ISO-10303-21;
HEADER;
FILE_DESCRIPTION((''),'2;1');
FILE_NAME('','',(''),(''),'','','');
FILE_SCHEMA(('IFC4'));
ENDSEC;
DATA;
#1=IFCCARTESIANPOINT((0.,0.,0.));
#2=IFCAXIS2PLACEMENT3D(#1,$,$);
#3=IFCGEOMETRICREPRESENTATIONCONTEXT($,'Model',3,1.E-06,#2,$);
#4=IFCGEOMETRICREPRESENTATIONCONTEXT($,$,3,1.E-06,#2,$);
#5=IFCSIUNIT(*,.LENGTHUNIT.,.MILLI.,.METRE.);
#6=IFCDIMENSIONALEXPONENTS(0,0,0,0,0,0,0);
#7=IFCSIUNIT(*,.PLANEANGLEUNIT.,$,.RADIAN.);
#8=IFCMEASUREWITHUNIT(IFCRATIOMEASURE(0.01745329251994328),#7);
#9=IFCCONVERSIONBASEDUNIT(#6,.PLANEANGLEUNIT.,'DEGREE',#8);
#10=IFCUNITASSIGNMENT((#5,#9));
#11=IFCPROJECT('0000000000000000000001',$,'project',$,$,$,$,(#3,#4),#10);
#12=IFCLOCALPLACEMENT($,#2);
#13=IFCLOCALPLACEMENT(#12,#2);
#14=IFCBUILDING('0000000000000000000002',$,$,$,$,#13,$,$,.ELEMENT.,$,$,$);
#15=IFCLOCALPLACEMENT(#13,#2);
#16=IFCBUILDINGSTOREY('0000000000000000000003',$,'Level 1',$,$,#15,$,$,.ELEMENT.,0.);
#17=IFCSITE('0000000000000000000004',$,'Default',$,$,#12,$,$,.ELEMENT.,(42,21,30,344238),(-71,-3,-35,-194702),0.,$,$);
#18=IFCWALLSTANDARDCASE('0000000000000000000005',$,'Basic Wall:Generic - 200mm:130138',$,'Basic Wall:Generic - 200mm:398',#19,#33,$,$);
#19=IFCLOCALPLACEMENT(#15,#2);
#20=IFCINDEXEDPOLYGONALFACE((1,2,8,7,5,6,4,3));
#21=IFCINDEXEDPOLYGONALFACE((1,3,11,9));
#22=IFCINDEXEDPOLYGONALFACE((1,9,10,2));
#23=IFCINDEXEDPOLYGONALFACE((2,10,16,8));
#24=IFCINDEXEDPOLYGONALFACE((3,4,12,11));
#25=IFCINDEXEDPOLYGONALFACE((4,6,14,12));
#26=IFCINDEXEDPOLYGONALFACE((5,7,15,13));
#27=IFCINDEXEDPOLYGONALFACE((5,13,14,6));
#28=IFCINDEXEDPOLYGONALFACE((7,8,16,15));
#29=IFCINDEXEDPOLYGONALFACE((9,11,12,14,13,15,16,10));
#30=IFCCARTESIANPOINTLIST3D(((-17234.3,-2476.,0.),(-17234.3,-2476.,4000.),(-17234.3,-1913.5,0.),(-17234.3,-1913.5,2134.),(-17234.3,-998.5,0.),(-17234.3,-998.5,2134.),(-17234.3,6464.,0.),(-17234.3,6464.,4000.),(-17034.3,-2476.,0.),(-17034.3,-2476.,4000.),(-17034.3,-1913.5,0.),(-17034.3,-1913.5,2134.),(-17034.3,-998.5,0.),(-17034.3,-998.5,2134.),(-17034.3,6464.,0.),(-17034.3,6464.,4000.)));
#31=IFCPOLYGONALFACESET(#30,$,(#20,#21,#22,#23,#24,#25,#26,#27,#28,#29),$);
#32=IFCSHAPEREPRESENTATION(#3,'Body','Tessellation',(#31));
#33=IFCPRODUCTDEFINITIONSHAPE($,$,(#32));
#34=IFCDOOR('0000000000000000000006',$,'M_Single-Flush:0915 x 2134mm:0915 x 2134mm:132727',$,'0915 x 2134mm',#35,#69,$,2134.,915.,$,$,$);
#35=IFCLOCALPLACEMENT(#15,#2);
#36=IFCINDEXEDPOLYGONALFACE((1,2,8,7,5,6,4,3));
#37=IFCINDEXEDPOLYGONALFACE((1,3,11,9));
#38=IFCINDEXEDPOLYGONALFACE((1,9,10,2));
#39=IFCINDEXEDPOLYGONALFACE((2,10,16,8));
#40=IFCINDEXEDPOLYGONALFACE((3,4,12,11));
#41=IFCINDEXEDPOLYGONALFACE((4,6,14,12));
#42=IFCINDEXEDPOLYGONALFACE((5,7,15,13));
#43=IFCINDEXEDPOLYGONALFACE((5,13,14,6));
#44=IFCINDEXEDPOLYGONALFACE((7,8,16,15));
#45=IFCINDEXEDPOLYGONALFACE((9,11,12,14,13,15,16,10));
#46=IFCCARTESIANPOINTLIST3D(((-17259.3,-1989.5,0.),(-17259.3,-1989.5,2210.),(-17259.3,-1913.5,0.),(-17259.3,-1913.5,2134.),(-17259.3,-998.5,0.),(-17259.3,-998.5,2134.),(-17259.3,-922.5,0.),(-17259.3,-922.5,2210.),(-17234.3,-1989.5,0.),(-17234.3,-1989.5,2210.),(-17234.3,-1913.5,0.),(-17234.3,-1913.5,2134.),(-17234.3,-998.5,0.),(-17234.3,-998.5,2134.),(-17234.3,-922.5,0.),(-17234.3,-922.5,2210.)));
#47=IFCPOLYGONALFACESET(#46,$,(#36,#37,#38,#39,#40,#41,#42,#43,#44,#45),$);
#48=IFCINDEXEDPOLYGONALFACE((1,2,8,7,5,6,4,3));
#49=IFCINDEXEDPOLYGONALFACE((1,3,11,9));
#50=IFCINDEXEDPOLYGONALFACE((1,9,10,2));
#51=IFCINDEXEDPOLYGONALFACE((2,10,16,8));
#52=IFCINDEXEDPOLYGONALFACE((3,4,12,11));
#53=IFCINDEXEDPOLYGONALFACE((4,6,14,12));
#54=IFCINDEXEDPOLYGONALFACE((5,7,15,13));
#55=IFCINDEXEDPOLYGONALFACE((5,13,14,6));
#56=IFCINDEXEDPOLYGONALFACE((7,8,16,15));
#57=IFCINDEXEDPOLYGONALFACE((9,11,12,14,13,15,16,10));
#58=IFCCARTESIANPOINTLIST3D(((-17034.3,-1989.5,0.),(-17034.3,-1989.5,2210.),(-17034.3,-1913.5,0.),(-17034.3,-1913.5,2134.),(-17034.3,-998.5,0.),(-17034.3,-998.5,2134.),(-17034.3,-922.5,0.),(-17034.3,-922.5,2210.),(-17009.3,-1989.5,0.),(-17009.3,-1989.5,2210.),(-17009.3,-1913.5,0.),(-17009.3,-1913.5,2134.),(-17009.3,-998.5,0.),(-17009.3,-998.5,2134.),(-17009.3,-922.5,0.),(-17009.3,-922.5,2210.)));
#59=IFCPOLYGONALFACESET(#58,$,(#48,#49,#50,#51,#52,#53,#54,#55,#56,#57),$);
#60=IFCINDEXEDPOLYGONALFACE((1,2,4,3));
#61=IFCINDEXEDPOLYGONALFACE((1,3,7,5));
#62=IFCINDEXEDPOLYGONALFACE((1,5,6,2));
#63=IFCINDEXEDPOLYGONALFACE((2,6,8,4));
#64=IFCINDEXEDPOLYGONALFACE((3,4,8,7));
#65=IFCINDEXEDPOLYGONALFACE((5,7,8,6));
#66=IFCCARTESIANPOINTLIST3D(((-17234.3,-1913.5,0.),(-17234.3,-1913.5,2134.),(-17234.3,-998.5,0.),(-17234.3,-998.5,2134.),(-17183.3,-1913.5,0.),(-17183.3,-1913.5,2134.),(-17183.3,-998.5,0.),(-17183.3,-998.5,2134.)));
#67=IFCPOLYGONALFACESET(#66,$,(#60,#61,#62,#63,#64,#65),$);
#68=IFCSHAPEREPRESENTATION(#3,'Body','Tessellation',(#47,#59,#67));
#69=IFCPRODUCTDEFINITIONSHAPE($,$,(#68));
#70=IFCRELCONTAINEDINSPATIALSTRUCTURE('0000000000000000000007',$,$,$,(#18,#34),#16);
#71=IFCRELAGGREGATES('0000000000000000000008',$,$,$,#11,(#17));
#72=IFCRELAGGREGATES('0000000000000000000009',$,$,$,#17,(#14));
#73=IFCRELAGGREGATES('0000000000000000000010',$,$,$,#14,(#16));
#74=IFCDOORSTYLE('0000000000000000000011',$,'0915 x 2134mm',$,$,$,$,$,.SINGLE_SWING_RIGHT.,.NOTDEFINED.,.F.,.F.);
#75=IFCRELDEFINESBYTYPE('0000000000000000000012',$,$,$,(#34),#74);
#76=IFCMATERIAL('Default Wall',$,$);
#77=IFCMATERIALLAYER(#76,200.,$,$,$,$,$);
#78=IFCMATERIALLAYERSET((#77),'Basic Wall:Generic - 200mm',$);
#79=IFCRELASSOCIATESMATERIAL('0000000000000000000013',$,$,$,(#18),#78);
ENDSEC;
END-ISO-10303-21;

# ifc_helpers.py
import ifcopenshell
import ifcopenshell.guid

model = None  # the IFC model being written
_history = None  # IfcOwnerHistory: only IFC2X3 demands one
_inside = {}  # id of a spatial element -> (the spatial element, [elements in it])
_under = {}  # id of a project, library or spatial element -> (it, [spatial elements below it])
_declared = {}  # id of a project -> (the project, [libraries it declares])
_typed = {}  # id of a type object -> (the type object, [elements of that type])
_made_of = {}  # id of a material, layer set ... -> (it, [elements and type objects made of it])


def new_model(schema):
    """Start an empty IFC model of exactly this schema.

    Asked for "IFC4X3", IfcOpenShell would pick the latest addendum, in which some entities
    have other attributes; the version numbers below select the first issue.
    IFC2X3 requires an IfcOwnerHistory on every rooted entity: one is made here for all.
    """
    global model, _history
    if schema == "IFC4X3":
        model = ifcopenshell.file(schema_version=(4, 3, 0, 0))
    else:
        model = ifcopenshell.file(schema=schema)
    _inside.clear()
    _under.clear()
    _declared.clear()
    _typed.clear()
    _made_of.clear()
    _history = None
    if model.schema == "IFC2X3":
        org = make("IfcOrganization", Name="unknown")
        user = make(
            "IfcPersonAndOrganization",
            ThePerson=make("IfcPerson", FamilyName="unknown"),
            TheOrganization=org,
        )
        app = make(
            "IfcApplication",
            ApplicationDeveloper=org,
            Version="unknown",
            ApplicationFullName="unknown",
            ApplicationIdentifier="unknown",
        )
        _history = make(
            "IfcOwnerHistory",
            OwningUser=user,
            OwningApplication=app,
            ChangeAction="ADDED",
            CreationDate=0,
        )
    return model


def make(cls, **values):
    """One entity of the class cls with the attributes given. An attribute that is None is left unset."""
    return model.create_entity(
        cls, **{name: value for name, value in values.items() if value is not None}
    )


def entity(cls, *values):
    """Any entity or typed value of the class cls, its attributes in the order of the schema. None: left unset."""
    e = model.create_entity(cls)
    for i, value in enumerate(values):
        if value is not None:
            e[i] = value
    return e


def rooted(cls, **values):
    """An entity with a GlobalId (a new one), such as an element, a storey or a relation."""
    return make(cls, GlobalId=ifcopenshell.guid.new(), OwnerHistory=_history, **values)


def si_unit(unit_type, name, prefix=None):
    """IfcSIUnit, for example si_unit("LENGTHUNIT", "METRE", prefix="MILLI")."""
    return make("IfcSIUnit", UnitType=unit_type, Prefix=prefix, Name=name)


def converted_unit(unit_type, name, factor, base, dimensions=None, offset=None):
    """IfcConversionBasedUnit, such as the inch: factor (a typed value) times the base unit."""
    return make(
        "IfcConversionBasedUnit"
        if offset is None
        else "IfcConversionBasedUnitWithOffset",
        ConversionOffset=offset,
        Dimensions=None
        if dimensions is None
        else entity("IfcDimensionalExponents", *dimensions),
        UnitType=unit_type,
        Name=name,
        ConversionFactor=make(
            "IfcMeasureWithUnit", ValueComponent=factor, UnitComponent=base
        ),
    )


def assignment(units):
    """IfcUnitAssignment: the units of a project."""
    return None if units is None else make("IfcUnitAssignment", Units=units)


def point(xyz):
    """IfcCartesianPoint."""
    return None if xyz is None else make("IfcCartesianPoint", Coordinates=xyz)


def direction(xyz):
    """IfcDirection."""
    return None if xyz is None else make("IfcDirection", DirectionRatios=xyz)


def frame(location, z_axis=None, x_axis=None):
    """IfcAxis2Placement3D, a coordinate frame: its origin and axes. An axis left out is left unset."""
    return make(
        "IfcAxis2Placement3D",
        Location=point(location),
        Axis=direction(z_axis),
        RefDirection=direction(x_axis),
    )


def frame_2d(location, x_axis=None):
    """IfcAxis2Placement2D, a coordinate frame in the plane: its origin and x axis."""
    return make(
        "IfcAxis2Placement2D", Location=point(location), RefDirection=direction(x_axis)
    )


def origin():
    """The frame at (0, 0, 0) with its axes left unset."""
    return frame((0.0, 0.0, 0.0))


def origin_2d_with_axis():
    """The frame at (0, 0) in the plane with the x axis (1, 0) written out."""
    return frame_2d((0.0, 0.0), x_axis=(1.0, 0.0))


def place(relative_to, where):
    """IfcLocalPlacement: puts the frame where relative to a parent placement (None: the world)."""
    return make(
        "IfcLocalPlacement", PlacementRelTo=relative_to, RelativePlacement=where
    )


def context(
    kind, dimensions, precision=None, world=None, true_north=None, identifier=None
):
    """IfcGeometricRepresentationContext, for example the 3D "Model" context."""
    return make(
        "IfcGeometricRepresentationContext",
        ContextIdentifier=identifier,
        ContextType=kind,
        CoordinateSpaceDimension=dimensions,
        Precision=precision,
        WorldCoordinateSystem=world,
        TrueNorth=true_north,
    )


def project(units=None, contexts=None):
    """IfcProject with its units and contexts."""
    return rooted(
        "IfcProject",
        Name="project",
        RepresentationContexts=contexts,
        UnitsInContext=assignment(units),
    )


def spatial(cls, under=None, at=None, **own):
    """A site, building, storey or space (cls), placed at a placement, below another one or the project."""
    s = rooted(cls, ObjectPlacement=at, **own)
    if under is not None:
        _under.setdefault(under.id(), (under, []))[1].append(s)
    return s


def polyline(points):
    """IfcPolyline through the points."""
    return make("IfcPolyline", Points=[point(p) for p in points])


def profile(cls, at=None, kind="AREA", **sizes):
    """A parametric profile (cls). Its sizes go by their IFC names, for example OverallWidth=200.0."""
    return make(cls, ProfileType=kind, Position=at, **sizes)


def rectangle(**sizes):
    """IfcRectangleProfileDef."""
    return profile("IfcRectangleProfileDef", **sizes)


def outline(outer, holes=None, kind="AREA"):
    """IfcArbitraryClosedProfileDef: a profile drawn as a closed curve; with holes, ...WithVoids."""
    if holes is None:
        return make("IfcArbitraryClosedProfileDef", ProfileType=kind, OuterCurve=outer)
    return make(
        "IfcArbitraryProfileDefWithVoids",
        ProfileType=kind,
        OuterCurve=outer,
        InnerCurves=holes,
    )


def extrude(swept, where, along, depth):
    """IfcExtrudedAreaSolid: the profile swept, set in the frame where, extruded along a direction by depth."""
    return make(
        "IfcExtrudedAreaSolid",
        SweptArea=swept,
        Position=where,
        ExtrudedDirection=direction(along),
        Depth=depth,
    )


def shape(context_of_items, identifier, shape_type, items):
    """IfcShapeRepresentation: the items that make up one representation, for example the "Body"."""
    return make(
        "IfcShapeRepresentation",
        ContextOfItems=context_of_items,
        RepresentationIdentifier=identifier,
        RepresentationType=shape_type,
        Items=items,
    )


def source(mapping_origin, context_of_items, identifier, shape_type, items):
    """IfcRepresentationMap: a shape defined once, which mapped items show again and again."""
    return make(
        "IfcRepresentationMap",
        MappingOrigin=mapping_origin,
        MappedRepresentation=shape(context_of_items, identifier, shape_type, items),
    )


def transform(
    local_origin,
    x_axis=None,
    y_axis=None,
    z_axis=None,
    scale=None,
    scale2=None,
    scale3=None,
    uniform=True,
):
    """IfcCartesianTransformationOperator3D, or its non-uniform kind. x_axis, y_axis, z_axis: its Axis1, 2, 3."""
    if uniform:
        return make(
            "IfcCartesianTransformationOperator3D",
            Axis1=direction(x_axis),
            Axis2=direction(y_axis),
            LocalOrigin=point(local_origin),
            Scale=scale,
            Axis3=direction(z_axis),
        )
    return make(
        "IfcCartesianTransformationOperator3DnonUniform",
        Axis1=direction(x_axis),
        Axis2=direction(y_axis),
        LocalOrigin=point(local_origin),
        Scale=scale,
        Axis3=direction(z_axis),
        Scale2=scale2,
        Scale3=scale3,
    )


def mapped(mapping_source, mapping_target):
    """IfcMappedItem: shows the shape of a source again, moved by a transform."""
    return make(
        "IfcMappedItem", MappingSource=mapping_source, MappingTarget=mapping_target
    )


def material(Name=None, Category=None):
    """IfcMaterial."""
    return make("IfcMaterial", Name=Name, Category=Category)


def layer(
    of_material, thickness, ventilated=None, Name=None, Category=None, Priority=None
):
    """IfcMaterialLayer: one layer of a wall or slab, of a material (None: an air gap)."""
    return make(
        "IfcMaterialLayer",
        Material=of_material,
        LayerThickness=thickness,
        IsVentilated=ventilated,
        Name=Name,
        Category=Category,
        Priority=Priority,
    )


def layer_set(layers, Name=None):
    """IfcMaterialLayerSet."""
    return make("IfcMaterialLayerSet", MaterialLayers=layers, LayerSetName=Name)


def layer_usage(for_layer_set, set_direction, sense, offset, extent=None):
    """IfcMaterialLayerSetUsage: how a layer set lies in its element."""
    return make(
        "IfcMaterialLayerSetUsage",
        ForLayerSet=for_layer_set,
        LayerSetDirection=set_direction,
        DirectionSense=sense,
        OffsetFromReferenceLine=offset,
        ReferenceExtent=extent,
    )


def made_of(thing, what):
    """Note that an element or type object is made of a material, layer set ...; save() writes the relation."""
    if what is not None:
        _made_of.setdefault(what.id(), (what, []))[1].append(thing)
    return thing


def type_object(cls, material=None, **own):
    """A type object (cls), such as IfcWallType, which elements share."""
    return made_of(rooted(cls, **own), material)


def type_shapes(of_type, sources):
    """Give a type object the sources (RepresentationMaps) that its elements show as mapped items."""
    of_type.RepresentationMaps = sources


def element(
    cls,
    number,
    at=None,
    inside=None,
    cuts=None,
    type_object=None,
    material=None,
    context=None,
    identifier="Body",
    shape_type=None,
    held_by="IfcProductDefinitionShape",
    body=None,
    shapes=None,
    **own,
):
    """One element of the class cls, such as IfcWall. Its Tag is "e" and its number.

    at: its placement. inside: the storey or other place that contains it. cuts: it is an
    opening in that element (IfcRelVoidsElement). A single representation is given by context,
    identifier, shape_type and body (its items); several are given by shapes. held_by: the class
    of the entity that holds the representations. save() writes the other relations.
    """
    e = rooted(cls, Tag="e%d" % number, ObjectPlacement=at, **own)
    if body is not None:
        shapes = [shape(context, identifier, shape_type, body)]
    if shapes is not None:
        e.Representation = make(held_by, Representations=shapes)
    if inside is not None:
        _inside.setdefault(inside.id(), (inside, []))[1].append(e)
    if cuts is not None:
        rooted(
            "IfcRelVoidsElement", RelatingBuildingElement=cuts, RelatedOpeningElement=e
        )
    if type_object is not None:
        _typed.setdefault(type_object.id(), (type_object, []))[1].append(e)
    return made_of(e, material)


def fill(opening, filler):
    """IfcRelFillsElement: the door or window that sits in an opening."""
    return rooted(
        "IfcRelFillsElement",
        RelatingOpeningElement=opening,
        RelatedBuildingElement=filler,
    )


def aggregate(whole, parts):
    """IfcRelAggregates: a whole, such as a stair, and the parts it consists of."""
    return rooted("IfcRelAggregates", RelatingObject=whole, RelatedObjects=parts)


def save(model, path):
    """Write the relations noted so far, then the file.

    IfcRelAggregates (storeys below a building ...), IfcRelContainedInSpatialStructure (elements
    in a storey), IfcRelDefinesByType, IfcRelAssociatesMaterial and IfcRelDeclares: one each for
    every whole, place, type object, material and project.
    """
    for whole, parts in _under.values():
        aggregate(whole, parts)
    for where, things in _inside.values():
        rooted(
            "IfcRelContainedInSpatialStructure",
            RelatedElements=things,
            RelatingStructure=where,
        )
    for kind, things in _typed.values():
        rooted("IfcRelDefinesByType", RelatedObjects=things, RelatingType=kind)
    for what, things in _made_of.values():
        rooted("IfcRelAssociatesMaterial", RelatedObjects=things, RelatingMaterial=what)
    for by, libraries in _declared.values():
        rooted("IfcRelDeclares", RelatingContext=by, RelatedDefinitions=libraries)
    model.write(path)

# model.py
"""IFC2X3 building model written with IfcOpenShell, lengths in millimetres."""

from ifc_helpers import new_model, entity, si_unit, converted_unit, frame, frame_2d, origin, origin_2d_with_axis, place, context, project, spatial, polyline, rectangle, outline, extrude, source, transform, mapped, material, layer, layer_set, layer_usage, type_object, type_shapes, element, fill, save


model = new_model("IFC2X3")

# Units and contexts
model_context = context("Model", 3, precision=1e-06, world=origin())
context_of_model = context(None, 3, precision=1e-06, world=origin())
ifc_project = project(units=[si_unit("LENGTHUNIT", "METRE", prefix="MILLI"), converted_unit("PLANEANGLEUNIT", "DEGREE", entity("IfcRatioMeasure", 0.01745329251994328), si_unit("PLANEANGLEUNIT", "RADIAN"), dimensions=[0, 0, 0, 0, 0, 0, 0])], contexts=[model_context, context_of_model])

# Site, building, storey
site_placement = place(None, origin())
site = spatial("IfcSite", under=ifc_project, at=site_placement, Name="Default", CompositionType="ELEMENT", RefLatitude=(42, 21, 30, 344238), RefLongitude=(-71, -3, -35, -194702), RefElevation=0.0)
building_placement = place(site_placement, origin())
building = spatial("IfcBuilding", under=site, at=building_placement, CompositionType="ELEMENT")
storey_placement = place(building_placement, origin())
storey = spatial("IfcBuildingStorey", under=building, at=storey_placement, Name="Level 1", CompositionType="ELEMENT", Elevation=0.0)

# Wall, opening, door
ifc_material_1 = material(Name="Default Wall")
ifc_layer_1 = layer(ifc_material_1, 200.0)
ifc_layer_set_1 = layer_set([ifc_layer_1], Name="Basic Wall:Generic - 200mm")
ifc_layer_usage_1 = layer_usage(ifc_layer_set_1, "AXIS2", "NEGATIVE", 100.0)
wall_1_placement = place(storey_placement, frame((-17134.3, -2476.0, 0.0), z_axis=(0.0, 0.0, 1.0), x_axis=(0.0, 1.0, 0.0)))
wall_1 = element("IfcWallStandardCase", 1, at=wall_1_placement, inside=storey, material=ifc_layer_usage_1, Name="Basic Wall:Generic - 200mm:130138", ObjectType="Basic Wall:Generic - 200mm:398", context=model_context, shape_type="SweptSolid", body=[
    extrude(rectangle(XDim=8940.0, YDim=200.0, at=frame_2d((4470.0, 0.0), x_axis=(-1.0, 0.0))), origin(), (0.0, 0.0, 1.0), 4000.0),
])
opening_1_placement = place(wall_1_placement, frame((562.5, -100.0, 0.0)))
opening_1 = element("IfcOpeningElement", 2, at=opening_1_placement, cuts=wall_1, ObjectType="Opening", context=model_context, shape_type="SweptSolid", body=[
    extrude(rectangle(XDim=915.0, YDim=2134.0, at=frame_2d((1067.0, 457.5), x_axis=(0.0, 1.0))), frame((0.0, 0.0, 0.0), z_axis=(0.0, 1.0, 0.0), x_axis=(0.0, 0.0, 1.0)), (0.0, 0.0, 1.0), 200.0),
])
door_style = type_object("IfcDoorStyle", Name="0915 x 2134mm", ConstructionType="NOTDEFINED", OperationType="SINGLE_SWING_RIGHT", ParameterTakesPrecedence=False, Sizeable=False)
shared_shape_1 = source(origin(), model_context, "Body", "SweptSolid", [
    extrude(outline(polyline([(-533.5, -1124.0), (533.5, -1124.0), (533.5, 1086.0), (457.5, 1086.0), (457.5, -1048.0), (-457.5, -1048.0), (-457.5, 1086.0), (-533.5, 1086.0), (-533.5, -1124.0)])), frame((457.5, 200.0, 1086.0), z_axis=(0.0, 1.0, 0.0), x_axis=(1.0, 0.0, 0.0)), (0.0, 0.0, 1.0), 25.0),
    extrude(outline(polyline([(-1124.0, -533.5), (1086.0, -533.5), (1086.0, -457.5), (-1048.0, -457.5), (-1048.0, 457.5), (1086.0, 457.5), (1086.0, 533.5), (-1124.0, 533.5), (-1124.0, -533.5)])), frame((457.5, -25.0, 1086.0), z_axis=(0.0, 1.0, 0.0), x_axis=(0.0, 0.0, -1.0)), (0.0, 0.0, 1.0), 25.0),
    extrude(rectangle(XDim=51.0, YDim=915.0, at=origin_2d_with_axis()), frame((457.5, 174.5, 0.0), z_axis=(0.0, 0.0, 1.0), x_axis=(0.0, 1.0, 0.0)), (0.0, 0.0, 1.0), 2134.0),
])
type_shapes(door_style, [shared_shape_1])
door_placement = place(opening_1_placement, origin())
door = element("IfcDoor", 3, at=door_placement, inside=storey, type_object=door_style, Name="M_Single-Flush:0915 x 2134mm:0915 x 2134mm:132727", ObjectType="0915 x 2134mm", OverallHeight=2134.0, OverallWidth=915.0, context=model_context, shape_type="MappedRepresentation", body=[
    mapped(shared_shape_1, transform((0.0, 0.0, 0.0), scale=1.0)),
])
fill(opening_1, door)

save(model, "model.ifc")
